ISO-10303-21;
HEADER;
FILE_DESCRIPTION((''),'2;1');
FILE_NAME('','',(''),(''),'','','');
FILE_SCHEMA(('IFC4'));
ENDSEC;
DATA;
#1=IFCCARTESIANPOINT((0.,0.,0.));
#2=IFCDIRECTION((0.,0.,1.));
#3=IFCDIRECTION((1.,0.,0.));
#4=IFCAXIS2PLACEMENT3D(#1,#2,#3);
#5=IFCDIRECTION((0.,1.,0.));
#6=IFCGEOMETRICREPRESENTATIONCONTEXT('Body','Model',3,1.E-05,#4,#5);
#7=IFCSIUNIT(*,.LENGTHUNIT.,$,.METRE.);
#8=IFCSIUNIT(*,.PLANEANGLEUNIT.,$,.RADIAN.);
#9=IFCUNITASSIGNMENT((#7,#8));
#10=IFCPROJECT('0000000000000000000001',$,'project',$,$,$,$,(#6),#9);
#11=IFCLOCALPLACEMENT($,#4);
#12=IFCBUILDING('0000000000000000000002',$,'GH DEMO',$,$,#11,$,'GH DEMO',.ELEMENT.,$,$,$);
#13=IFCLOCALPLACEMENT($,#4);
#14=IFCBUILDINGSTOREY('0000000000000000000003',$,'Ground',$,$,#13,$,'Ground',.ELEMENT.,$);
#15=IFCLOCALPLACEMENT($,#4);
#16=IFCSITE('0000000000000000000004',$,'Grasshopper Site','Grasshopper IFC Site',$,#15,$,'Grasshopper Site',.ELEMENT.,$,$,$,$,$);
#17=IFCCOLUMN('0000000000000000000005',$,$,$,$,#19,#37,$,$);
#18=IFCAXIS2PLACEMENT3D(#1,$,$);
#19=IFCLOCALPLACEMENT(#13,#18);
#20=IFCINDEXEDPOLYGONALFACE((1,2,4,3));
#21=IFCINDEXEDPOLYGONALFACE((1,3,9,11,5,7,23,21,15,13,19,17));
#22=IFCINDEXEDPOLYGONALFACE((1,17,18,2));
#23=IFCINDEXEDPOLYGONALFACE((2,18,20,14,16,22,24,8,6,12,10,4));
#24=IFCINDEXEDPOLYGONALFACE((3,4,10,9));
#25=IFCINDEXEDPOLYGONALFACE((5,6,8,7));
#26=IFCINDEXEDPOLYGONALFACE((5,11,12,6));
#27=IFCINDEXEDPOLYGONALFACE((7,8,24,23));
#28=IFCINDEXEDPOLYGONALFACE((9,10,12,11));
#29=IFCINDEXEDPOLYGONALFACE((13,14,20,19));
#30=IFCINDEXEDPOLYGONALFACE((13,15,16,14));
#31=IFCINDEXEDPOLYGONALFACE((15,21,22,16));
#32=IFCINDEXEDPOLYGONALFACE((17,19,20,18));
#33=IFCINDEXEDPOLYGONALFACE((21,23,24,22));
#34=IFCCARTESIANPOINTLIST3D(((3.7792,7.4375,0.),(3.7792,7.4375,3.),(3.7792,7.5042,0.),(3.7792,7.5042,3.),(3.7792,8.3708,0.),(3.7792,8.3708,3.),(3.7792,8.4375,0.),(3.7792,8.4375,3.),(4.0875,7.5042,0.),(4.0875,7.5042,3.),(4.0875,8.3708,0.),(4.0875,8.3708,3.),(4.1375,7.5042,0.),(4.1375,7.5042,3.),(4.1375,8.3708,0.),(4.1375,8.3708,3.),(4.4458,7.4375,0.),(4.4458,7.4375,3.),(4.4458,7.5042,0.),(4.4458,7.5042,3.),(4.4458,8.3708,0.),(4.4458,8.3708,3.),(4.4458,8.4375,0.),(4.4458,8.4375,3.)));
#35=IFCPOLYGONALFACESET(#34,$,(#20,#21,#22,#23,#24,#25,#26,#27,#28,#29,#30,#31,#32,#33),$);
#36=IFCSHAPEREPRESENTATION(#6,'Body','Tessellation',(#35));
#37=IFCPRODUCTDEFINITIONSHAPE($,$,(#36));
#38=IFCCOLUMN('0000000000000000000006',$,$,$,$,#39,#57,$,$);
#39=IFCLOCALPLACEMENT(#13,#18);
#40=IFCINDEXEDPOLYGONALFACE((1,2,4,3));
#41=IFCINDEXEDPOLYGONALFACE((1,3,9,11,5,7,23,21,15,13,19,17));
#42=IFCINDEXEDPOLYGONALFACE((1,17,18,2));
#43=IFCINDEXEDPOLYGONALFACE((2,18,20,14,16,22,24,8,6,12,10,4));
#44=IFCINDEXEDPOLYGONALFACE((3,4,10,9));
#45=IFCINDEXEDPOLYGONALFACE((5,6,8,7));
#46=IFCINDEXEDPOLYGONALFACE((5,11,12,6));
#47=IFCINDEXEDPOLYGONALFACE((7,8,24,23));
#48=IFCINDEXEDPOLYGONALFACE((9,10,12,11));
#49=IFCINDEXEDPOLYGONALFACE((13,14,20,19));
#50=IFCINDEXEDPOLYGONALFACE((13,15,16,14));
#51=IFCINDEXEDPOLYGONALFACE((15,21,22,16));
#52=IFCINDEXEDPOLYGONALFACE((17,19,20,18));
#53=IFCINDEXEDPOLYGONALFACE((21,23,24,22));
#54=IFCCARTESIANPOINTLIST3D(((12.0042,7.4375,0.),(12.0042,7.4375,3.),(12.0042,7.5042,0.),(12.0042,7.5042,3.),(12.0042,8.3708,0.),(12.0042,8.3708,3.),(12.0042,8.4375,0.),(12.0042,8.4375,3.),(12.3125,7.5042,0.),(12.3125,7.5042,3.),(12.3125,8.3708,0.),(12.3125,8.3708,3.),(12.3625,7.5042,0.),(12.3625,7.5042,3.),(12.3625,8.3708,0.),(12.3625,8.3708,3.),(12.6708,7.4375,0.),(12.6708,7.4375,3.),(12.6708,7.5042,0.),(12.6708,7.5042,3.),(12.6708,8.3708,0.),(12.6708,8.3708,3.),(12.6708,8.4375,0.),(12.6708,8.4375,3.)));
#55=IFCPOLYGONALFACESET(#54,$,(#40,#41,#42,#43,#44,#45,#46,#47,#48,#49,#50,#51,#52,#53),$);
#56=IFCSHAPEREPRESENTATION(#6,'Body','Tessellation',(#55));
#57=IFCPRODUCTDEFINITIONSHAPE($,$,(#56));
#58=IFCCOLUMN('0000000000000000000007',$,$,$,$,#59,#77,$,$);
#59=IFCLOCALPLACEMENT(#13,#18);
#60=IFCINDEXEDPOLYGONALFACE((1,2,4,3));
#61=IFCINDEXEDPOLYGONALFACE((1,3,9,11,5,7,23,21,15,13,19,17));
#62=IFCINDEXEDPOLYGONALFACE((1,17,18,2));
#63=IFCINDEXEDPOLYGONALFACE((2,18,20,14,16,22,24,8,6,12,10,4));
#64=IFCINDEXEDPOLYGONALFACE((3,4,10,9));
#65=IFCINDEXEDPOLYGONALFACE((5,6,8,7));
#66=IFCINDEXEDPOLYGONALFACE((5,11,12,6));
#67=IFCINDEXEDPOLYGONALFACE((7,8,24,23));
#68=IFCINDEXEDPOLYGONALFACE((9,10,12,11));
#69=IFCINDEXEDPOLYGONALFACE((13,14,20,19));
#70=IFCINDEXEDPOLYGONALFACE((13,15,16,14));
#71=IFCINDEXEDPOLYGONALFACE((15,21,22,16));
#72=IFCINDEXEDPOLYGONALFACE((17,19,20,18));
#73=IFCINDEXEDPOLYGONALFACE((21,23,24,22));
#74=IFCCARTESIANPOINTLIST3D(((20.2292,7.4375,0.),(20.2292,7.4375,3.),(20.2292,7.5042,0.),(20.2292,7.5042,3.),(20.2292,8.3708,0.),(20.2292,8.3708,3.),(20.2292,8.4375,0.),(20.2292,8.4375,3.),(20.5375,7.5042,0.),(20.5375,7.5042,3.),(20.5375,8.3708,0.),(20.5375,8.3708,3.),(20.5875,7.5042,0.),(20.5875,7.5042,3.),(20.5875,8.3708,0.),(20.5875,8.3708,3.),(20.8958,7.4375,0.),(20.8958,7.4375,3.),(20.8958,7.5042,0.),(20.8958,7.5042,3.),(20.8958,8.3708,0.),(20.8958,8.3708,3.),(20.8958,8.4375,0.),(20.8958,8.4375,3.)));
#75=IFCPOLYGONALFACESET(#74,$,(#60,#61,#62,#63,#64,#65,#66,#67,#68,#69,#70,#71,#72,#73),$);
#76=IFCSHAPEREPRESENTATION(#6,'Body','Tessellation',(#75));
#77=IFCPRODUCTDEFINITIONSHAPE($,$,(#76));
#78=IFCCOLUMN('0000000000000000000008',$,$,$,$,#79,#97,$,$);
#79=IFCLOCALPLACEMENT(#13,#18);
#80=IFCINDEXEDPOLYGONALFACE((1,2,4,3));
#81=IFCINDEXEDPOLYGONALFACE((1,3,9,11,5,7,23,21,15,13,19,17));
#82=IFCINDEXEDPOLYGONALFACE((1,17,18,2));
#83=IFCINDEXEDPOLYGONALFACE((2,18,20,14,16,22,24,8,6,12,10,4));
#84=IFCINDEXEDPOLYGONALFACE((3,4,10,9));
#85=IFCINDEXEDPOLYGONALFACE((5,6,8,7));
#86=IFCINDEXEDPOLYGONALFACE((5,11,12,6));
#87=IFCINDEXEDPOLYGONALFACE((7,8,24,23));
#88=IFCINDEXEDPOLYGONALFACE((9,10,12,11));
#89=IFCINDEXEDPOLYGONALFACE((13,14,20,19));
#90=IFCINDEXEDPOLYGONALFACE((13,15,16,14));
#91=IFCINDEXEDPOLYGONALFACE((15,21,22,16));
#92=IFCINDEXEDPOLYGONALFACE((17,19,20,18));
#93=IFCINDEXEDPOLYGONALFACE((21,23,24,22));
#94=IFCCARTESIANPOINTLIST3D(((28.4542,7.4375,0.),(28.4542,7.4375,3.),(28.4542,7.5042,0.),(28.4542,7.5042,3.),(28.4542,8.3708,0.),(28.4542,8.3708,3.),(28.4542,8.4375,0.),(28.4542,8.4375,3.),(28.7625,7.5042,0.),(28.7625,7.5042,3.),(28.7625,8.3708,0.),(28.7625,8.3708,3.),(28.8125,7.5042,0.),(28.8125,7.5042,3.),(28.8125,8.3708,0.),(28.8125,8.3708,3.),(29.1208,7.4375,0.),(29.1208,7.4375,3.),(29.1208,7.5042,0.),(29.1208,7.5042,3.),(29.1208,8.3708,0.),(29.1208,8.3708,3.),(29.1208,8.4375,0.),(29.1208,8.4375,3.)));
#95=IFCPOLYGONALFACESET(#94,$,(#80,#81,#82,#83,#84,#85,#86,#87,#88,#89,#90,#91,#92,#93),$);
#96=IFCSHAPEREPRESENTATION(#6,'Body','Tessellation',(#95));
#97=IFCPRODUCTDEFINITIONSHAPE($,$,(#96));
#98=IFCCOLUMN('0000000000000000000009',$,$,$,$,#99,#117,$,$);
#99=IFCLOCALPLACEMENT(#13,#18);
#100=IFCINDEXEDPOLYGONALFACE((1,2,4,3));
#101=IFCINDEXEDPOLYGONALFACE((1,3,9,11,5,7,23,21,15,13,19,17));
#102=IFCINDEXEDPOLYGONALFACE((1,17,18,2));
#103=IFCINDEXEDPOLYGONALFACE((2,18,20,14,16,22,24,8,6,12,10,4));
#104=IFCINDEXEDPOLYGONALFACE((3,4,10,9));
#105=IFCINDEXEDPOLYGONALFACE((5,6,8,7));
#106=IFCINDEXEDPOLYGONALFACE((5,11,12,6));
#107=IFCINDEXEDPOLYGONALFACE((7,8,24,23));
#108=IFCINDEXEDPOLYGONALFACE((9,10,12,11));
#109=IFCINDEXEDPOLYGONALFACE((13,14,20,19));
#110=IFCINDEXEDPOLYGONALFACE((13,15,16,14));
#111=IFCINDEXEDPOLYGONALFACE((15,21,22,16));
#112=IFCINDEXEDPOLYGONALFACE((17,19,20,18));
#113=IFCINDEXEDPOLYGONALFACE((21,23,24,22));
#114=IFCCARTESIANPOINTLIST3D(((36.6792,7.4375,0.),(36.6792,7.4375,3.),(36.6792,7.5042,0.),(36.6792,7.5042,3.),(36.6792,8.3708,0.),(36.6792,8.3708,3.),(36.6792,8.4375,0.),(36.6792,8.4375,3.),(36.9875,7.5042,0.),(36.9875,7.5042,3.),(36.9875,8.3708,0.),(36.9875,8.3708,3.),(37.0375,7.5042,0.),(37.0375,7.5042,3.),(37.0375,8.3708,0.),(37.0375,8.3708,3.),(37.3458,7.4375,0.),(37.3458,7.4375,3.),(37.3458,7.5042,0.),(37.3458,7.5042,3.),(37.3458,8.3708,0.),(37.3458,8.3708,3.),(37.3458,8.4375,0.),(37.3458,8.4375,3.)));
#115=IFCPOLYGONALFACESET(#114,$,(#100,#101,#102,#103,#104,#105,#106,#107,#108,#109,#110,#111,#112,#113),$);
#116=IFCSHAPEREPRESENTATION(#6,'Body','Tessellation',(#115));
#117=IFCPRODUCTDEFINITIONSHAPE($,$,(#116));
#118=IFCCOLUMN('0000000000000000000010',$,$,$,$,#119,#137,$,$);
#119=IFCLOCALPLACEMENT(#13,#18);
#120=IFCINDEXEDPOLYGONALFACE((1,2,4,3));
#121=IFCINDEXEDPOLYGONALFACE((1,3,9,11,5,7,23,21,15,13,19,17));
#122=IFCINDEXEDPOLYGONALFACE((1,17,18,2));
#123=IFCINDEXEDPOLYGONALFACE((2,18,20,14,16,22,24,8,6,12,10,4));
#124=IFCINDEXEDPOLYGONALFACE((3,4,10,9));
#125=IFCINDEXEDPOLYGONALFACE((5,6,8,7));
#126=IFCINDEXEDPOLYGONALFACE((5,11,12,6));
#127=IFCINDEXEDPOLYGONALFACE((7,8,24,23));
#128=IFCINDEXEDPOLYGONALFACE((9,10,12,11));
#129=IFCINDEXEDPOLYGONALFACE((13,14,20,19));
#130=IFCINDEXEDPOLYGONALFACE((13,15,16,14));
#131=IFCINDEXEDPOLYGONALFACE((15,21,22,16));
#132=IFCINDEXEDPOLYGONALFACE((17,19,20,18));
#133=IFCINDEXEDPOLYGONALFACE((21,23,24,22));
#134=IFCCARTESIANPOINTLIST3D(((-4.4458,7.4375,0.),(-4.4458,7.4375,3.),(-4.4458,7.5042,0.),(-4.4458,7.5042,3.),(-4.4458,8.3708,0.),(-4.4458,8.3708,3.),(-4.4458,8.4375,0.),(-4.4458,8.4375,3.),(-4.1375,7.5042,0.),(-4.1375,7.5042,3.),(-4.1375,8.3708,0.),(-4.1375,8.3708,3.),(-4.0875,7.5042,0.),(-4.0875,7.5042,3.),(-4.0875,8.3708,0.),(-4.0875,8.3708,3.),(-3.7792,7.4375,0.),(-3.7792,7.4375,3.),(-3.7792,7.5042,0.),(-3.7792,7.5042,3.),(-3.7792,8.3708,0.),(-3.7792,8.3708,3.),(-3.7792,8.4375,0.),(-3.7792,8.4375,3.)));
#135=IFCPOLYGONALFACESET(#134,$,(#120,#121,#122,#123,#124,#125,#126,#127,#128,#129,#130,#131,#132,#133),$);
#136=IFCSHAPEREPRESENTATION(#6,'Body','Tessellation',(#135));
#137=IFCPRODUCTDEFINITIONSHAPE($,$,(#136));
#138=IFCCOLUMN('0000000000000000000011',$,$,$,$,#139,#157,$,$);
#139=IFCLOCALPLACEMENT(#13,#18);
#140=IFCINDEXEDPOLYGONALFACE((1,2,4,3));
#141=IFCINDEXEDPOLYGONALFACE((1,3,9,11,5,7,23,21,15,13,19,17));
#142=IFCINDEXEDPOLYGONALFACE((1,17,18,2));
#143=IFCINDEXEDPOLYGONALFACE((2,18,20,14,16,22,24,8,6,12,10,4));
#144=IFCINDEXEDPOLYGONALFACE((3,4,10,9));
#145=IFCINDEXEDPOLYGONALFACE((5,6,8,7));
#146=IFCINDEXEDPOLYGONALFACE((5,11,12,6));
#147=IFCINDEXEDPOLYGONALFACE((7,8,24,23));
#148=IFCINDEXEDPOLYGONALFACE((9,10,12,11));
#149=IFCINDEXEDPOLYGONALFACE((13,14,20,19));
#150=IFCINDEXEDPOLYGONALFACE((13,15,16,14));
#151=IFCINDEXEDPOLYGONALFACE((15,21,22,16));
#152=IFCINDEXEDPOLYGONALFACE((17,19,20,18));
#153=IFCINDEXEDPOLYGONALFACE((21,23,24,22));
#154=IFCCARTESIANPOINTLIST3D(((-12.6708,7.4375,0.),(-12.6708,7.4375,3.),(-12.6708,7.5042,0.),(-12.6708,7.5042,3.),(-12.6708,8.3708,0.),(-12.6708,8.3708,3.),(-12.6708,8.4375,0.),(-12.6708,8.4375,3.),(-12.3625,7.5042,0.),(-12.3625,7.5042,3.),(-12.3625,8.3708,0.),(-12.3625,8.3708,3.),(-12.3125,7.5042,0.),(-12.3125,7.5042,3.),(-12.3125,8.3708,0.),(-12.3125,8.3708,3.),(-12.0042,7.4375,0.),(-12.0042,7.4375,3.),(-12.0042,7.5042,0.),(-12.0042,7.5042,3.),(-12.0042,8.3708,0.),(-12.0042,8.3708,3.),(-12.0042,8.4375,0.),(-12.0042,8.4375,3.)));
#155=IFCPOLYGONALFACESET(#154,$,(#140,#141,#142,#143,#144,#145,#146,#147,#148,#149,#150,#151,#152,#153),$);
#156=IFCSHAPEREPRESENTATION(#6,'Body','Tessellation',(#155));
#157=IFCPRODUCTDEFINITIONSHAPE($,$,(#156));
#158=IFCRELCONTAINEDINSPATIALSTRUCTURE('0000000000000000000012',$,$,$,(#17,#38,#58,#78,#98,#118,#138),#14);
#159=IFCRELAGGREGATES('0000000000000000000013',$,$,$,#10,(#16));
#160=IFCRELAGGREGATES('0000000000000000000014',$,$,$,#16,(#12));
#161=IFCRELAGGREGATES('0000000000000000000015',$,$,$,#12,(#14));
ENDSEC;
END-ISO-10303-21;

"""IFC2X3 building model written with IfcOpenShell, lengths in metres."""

from ifc_helpers import new_model, si_unit, direction, origin_with_axes, place, context, project, spatial, polyline, outline, extrude, source, transform, mapped, element, save


model = new_model("IFC2X3")

# Units and contexts
model_context = context("Model", 3, precision=1e-05, world=origin_with_axes(), true_north=direction((0.0, 1.0, 0.0)), identifier="Body")
ifc_project = project(units=[si_unit("LENGTHUNIT", "METRE"), si_unit("PLANEANGLEUNIT", "RADIAN")], contexts=[model_context])

# Site, building, storey
site_placement = place(None, origin_with_axes())
site = spatial("IfcSite", under=ifc_project, at=site_placement, Name="Grasshopper Site", Description="Grasshopper IFC Site", LongName="Grasshopper Site", CompositionType="ELEMENT")
building_placement = place(None, origin_with_axes())
building = spatial("IfcBuilding", under=site, at=building_placement, Name="GH DEMO", LongName="GH DEMO", CompositionType="ELEMENT")
storey_placement = place(None, origin_with_axes())
storey = spatial("IfcBuildingStorey", under=building, at=storey_placement, Name="Ground", LongName="Ground", CompositionType="ELEMENT")

# Columns
shared_shape_1 = source(origin_with_axes(), model_context, "Body", "SweptSolid", [
    extrude(outline(polyline([(0.025, -0.4333), (0.025, 0.4333), (0.3333, 0.4333), (0.3333, 0.5), (-0.3333, 0.5), (-0.3333, 0.4333), (-0.025, 0.4333), (-0.025, -0.4333), (-0.3333, -0.4333), (-0.3333, -0.5), (0.3333, -0.5), (0.3333, -0.4333), (0.025, -0.4333)])), origin_with_axes(), (0.0, 0.0, 1.0), 3.0),
])
column_1_placement = place(None, origin_with_axes())
element("IfcColumn", 1, at=column_1_placement, inside=storey, context=model_context, shape_type="MappedRepresentation", body=[
    mapped(shared_shape_1, transform((4.1125, 7.9375, 0.0), x_axis=(1.0, 0.0, 0.0), y_axis=(0.0, 1.0, 0.0), z_axis=(0.0, 0.0, 1.0), scale=1.0)),
])
shared_shape_2 = source(origin_with_axes(), model_context, "Body", "SweptSolid", [
    extrude(outline(polyline([(0.025, -0.4333), (0.025, 0.4333), (0.3333, 0.4333), (0.3333, 0.5), (-0.3333, 0.5), (-0.3333, 0.4333), (-0.025, 0.4333), (-0.025, -0.4333), (-0.3333, -0.4333), (-0.3333, -0.5), (0.3333, -0.5), (0.3333, -0.4333), (0.025, -0.4333)])), origin_with_axes(), (0.0, 0.0, 1.0), 3.0),
])
column_2_placement = place(None, origin_with_axes())
element("IfcColumn", 2, at=column_2_placement, inside=storey, context=model_context, shape_type="MappedRepresentation", body=[
    mapped(shared_shape_2, transform((12.3375, 7.9375, 0.0), x_axis=(1.0, 0.0, 0.0), y_axis=(0.0, 1.0, 0.0), z_axis=(0.0, 0.0, 1.0), scale=1.0)),
])
shared_shape_3 = source(origin_with_axes(), model_context, "Body", "SweptSolid", [
    extrude(outline(polyline([(0.025, -0.4333), (0.025, 0.4333), (0.3333, 0.4333), (0.3333, 0.5), (-0.3333, 0.5), (-0.3333, 0.4333), (-0.025, 0.4333), (-0.025, -0.4333), (-0.3333, -0.4333), (-0.3333, -0.5), (0.3333, -0.5), (0.3333, -0.4333), (0.025, -0.4333)])), origin_with_axes(), (0.0, 0.0, 1.0), 3.0),
])
column_3_placement = place(None, origin_with_axes())
element("IfcColumn", 3, at=column_3_placement, inside=storey, context=model_context, shape_type="MappedRepresentation", body=[
    mapped(shared_shape_3, transform((20.5625, 7.9375, 0.0), x_axis=(1.0, 0.0, 0.0), y_axis=(0.0, 1.0, 0.0), z_axis=(0.0, 0.0, 1.0), scale=1.0)),
])
shared_shape_4 = source(origin_with_axes(), model_context, "Body", "SweptSolid", [
    extrude(outline(polyline([(0.025, -0.4333), (0.025, 0.4333), (0.3333, 0.4333), (0.3333, 0.5), (-0.3333, 0.5), (-0.3333, 0.4333), (-0.025, 0.4333), (-0.025, -0.4333), (-0.3333, -0.4333), (-0.3333, -0.5), (0.3333, -0.5), (0.3333, -0.4333), (0.025, -0.4333)])), origin_with_axes(), (0.0, 0.0, 1.0), 3.0),
])
column_4_placement = place(None, origin_with_axes())
element("IfcColumn", 4, at=column_4_placement, inside=storey, context=model_context, shape_type="MappedRepresentation", body=[
    mapped(shared_shape_4, transform((28.7875, 7.9375, 0.0), x_axis=(1.0, 0.0, 0.0), y_axis=(0.0, 1.0, 0.0), z_axis=(0.0, 0.0, 1.0), scale=1.0)),
])
shared_shape_5 = source(origin_with_axes(), model_context, "Body", "SweptSolid", [
    extrude(outline(polyline([(0.025, -0.4333), (0.025, 0.4333), (0.3333, 0.4333), (0.3333, 0.5), (-0.3333, 0.5), (-0.3333, 0.4333), (-0.025, 0.4333), (-0.025, -0.4333), (-0.3333, -0.4333), (-0.3333, -0.5), (0.3333, -0.5), (0.3333, -0.4333), (0.025, -0.4333)])), origin_with_axes(), (0.0, 0.0, 1.0), 3.0),
])
column_5_placement = place(None, origin_with_axes())
element("IfcColumn", 5, at=column_5_placement, inside=storey, context=model_context, shape_type="MappedRepresentation", body=[
    mapped(shared_shape_5, transform((37.0125, 7.9375, 0.0), x_axis=(1.0, 0.0, 0.0), y_axis=(0.0, 1.0, 0.0), z_axis=(0.0, 0.0, 1.0), scale=1.0)),
])
shared_shape_6 = source(origin_with_axes(), model_context, "Body", "SweptSolid", [
    extrude(outline(polyline([(0.025, -0.4333), (0.025, 0.4333), (0.3333, 0.4333), (0.3333, 0.5), (-0.3333, 0.5), (-0.3333, 0.4333), (-0.025, 0.4333), (-0.025, -0.4333), (-0.3333, -0.4333), (-0.3333, -0.5), (0.3333, -0.5), (0.3333, -0.4333), (0.025, -0.4333)])), origin_with_axes(), (0.0, 0.0, 1.0), 3.0),
])
column_6_placement = place(None, origin_with_axes())
element("IfcColumn", 6, at=column_6_placement, inside=storey, context=model_context, shape_type="MappedRepresentation", body=[
    mapped(shared_shape_6, transform((-4.1125, 7.9375, 0.0), x_axis=(1.0, 0.0, 0.0), y_axis=(0.0, 1.0, 0.0), z_axis=(0.0, 0.0, 1.0), scale=1.0)),
])
shared_shape_7 = source(origin_with_axes(), model_context, "Body", "SweptSolid", [
    extrude(outline(polyline([(0.025, -0.4333), (0.025, 0.4333), (0.3333, 0.4333), (0.3333, 0.5), (-0.3333, 0.5), (-0.3333, 0.4333), (-0.025, 0.4333), (-0.025, -0.4333), (-0.3333, -0.4333), (-0.3333, -0.5), (0.3333, -0.5), (0.3333, -0.4333), (0.025, -0.4333)])), origin_with_axes(), (0.0, 0.0, 1.0), 3.0),
])
column_7_placement = place(None, origin_with_axes())
element("IfcColumn", 7, at=column_7_placement, inside=storey, context=model_context, shape_type="MappedRepresentation", body=[
    mapped(shared_shape_7, transform((-12.3375, 7.9375, 0.0), x_axis=(1.0, 0.0, 0.0), y_axis=(0.0, 1.0, 0.0), z_axis=(0.0, 0.0, 1.0), scale=1.0)),
])

save(model, "model.ifc")
